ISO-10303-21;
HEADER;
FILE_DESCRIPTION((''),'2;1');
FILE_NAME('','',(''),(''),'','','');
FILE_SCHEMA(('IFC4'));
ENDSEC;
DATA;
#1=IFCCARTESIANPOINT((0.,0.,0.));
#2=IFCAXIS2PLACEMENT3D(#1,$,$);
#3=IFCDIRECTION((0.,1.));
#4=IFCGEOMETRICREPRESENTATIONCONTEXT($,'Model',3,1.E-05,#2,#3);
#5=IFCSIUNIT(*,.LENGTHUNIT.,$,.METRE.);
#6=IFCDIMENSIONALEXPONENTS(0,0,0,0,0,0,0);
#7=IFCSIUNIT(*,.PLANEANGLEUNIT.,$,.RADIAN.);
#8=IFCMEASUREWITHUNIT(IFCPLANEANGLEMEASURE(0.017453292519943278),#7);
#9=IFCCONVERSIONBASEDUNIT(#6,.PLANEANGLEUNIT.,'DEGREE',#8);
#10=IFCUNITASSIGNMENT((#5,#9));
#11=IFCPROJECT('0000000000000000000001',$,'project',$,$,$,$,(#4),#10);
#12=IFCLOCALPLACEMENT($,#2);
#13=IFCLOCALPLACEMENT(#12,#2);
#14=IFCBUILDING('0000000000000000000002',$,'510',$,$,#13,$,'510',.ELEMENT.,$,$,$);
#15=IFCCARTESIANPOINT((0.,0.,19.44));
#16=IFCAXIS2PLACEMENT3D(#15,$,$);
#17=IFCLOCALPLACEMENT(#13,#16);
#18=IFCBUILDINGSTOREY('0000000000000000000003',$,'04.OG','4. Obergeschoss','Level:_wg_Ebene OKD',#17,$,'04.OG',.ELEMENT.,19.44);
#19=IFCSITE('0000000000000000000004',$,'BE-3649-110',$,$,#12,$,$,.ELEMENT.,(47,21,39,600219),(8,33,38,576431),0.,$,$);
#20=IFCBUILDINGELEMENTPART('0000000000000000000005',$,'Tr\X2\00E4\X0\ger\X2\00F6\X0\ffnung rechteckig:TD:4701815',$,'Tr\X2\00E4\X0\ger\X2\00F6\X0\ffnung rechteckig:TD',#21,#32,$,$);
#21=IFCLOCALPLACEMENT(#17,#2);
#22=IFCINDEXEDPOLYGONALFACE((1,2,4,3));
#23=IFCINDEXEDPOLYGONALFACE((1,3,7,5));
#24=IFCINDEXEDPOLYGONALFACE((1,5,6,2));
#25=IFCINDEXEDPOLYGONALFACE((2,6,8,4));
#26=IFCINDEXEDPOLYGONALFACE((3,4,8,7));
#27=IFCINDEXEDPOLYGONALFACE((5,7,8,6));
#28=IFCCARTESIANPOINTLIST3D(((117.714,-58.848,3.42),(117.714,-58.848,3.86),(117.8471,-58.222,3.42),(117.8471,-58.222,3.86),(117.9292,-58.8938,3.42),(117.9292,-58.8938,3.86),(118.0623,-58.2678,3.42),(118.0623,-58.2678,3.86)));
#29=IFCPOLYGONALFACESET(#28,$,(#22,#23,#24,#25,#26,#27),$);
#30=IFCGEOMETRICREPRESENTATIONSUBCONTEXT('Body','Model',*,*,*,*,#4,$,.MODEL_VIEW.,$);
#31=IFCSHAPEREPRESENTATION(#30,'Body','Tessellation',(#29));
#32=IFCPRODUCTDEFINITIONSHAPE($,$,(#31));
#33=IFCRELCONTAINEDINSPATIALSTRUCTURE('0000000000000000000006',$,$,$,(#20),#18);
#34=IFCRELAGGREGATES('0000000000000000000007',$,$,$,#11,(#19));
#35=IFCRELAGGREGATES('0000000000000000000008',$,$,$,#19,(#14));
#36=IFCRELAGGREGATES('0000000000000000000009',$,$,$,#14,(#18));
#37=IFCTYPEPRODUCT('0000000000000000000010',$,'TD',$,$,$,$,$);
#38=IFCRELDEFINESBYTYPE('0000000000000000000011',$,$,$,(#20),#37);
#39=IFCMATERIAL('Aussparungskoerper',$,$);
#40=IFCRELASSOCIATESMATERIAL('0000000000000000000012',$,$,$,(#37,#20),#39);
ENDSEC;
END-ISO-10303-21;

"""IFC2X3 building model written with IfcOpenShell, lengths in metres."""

from ifc_helpers import new_model, entity, si_unit, converted_unit, direction, frame, frame_2d, origin, place, context, subcontext, project, spatial, rectangle, extrude, source, transform, mapped, material, type_object, type_shapes, element, save


model = new_model("IFC2X3")

# Units and contexts
model_context = context("Model", 3, precision=1e-05, world=origin(), true_north=direction((0.0, 1.0)))
body_context = subcontext(model_context, "Body", "Model", "MODEL_VIEW")
ifc_project = project(units=[si_unit("LENGTHUNIT", "METRE"), converted_unit("PLANEANGLEUNIT", "DEGREE", entity("IfcPlaneAngleMeasure", 0.017453292519943278), si_unit("PLANEANGLEUNIT", "RADIAN"), dimensions=[0, 0, 0, 0, 0, 0, 0])], contexts=[model_context])

# Site, building, storey
site_placement = place(None, origin())
site = spatial("IfcSite", under=ifc_project, at=site_placement, Name="BE-3649-110", CompositionType="ELEMENT", RefLatitude=(47, 21, 39, 600219), RefLongitude=(8, 33, 38, 576431), RefElevation=0.0)
building_placement = place(site_placement, origin())
building = spatial("IfcBuilding", under=site, at=building_placement, Name="510", LongName="510", CompositionType="ELEMENT")
storey_placement = place(building_placement, frame((0.0, 0.0, 19.44)))
storey = spatial("IfcBuildingStorey", under=building, at=storey_placement, Name="04.OG", Description="4. Obergeschoss", ObjectType="Level:_wg_Ebene OKD", LongName="04.OG", CompositionType="ELEMENT", Elevation=19.44)

# Building element part
ifc_material_1 = material(Name="Aussparungskoerper")
type_product_1 = type_object("IfcTypeProduct", Name="TD", material=ifc_material_1)
shared_shape_1 = source(origin(), body_context, "Body", "SweptSolid", [
    extrude(rectangle(XDim=0.64, YDim=0.22, at=frame_2d((0.0, 0.0), x_axis=(1.0, 0.0))), frame((117.8881, -58.5579, -0.44), z_axis=(0.0, 0.0, 1.0), x_axis=(-0.207912, -0.978148, 0.0)), (0.0, 0.0, 1.0), 0.44),
])
type_shapes(type_product_1, [shared_shape_1])
building_element_part_1_placement = place(storey_placement, frame((0.0, 0.0, 3.86)))
element("IfcBuildingElementPart", 1, at=building_element_part_1_placement, inside=storey, type_object=type_product_1, material=ifc_material_1, Name="Trägeröffnung rechteckig:TD:4701815", ObjectType="Trägeröffnung rechteckig:TD", context=body_context, shape_type="MappedRepresentation", body=[
    mapped(shared_shape_1, transform((0.0, 0.0, 0.0), scale=1.0)),
])

save(model, "model.ifc")
